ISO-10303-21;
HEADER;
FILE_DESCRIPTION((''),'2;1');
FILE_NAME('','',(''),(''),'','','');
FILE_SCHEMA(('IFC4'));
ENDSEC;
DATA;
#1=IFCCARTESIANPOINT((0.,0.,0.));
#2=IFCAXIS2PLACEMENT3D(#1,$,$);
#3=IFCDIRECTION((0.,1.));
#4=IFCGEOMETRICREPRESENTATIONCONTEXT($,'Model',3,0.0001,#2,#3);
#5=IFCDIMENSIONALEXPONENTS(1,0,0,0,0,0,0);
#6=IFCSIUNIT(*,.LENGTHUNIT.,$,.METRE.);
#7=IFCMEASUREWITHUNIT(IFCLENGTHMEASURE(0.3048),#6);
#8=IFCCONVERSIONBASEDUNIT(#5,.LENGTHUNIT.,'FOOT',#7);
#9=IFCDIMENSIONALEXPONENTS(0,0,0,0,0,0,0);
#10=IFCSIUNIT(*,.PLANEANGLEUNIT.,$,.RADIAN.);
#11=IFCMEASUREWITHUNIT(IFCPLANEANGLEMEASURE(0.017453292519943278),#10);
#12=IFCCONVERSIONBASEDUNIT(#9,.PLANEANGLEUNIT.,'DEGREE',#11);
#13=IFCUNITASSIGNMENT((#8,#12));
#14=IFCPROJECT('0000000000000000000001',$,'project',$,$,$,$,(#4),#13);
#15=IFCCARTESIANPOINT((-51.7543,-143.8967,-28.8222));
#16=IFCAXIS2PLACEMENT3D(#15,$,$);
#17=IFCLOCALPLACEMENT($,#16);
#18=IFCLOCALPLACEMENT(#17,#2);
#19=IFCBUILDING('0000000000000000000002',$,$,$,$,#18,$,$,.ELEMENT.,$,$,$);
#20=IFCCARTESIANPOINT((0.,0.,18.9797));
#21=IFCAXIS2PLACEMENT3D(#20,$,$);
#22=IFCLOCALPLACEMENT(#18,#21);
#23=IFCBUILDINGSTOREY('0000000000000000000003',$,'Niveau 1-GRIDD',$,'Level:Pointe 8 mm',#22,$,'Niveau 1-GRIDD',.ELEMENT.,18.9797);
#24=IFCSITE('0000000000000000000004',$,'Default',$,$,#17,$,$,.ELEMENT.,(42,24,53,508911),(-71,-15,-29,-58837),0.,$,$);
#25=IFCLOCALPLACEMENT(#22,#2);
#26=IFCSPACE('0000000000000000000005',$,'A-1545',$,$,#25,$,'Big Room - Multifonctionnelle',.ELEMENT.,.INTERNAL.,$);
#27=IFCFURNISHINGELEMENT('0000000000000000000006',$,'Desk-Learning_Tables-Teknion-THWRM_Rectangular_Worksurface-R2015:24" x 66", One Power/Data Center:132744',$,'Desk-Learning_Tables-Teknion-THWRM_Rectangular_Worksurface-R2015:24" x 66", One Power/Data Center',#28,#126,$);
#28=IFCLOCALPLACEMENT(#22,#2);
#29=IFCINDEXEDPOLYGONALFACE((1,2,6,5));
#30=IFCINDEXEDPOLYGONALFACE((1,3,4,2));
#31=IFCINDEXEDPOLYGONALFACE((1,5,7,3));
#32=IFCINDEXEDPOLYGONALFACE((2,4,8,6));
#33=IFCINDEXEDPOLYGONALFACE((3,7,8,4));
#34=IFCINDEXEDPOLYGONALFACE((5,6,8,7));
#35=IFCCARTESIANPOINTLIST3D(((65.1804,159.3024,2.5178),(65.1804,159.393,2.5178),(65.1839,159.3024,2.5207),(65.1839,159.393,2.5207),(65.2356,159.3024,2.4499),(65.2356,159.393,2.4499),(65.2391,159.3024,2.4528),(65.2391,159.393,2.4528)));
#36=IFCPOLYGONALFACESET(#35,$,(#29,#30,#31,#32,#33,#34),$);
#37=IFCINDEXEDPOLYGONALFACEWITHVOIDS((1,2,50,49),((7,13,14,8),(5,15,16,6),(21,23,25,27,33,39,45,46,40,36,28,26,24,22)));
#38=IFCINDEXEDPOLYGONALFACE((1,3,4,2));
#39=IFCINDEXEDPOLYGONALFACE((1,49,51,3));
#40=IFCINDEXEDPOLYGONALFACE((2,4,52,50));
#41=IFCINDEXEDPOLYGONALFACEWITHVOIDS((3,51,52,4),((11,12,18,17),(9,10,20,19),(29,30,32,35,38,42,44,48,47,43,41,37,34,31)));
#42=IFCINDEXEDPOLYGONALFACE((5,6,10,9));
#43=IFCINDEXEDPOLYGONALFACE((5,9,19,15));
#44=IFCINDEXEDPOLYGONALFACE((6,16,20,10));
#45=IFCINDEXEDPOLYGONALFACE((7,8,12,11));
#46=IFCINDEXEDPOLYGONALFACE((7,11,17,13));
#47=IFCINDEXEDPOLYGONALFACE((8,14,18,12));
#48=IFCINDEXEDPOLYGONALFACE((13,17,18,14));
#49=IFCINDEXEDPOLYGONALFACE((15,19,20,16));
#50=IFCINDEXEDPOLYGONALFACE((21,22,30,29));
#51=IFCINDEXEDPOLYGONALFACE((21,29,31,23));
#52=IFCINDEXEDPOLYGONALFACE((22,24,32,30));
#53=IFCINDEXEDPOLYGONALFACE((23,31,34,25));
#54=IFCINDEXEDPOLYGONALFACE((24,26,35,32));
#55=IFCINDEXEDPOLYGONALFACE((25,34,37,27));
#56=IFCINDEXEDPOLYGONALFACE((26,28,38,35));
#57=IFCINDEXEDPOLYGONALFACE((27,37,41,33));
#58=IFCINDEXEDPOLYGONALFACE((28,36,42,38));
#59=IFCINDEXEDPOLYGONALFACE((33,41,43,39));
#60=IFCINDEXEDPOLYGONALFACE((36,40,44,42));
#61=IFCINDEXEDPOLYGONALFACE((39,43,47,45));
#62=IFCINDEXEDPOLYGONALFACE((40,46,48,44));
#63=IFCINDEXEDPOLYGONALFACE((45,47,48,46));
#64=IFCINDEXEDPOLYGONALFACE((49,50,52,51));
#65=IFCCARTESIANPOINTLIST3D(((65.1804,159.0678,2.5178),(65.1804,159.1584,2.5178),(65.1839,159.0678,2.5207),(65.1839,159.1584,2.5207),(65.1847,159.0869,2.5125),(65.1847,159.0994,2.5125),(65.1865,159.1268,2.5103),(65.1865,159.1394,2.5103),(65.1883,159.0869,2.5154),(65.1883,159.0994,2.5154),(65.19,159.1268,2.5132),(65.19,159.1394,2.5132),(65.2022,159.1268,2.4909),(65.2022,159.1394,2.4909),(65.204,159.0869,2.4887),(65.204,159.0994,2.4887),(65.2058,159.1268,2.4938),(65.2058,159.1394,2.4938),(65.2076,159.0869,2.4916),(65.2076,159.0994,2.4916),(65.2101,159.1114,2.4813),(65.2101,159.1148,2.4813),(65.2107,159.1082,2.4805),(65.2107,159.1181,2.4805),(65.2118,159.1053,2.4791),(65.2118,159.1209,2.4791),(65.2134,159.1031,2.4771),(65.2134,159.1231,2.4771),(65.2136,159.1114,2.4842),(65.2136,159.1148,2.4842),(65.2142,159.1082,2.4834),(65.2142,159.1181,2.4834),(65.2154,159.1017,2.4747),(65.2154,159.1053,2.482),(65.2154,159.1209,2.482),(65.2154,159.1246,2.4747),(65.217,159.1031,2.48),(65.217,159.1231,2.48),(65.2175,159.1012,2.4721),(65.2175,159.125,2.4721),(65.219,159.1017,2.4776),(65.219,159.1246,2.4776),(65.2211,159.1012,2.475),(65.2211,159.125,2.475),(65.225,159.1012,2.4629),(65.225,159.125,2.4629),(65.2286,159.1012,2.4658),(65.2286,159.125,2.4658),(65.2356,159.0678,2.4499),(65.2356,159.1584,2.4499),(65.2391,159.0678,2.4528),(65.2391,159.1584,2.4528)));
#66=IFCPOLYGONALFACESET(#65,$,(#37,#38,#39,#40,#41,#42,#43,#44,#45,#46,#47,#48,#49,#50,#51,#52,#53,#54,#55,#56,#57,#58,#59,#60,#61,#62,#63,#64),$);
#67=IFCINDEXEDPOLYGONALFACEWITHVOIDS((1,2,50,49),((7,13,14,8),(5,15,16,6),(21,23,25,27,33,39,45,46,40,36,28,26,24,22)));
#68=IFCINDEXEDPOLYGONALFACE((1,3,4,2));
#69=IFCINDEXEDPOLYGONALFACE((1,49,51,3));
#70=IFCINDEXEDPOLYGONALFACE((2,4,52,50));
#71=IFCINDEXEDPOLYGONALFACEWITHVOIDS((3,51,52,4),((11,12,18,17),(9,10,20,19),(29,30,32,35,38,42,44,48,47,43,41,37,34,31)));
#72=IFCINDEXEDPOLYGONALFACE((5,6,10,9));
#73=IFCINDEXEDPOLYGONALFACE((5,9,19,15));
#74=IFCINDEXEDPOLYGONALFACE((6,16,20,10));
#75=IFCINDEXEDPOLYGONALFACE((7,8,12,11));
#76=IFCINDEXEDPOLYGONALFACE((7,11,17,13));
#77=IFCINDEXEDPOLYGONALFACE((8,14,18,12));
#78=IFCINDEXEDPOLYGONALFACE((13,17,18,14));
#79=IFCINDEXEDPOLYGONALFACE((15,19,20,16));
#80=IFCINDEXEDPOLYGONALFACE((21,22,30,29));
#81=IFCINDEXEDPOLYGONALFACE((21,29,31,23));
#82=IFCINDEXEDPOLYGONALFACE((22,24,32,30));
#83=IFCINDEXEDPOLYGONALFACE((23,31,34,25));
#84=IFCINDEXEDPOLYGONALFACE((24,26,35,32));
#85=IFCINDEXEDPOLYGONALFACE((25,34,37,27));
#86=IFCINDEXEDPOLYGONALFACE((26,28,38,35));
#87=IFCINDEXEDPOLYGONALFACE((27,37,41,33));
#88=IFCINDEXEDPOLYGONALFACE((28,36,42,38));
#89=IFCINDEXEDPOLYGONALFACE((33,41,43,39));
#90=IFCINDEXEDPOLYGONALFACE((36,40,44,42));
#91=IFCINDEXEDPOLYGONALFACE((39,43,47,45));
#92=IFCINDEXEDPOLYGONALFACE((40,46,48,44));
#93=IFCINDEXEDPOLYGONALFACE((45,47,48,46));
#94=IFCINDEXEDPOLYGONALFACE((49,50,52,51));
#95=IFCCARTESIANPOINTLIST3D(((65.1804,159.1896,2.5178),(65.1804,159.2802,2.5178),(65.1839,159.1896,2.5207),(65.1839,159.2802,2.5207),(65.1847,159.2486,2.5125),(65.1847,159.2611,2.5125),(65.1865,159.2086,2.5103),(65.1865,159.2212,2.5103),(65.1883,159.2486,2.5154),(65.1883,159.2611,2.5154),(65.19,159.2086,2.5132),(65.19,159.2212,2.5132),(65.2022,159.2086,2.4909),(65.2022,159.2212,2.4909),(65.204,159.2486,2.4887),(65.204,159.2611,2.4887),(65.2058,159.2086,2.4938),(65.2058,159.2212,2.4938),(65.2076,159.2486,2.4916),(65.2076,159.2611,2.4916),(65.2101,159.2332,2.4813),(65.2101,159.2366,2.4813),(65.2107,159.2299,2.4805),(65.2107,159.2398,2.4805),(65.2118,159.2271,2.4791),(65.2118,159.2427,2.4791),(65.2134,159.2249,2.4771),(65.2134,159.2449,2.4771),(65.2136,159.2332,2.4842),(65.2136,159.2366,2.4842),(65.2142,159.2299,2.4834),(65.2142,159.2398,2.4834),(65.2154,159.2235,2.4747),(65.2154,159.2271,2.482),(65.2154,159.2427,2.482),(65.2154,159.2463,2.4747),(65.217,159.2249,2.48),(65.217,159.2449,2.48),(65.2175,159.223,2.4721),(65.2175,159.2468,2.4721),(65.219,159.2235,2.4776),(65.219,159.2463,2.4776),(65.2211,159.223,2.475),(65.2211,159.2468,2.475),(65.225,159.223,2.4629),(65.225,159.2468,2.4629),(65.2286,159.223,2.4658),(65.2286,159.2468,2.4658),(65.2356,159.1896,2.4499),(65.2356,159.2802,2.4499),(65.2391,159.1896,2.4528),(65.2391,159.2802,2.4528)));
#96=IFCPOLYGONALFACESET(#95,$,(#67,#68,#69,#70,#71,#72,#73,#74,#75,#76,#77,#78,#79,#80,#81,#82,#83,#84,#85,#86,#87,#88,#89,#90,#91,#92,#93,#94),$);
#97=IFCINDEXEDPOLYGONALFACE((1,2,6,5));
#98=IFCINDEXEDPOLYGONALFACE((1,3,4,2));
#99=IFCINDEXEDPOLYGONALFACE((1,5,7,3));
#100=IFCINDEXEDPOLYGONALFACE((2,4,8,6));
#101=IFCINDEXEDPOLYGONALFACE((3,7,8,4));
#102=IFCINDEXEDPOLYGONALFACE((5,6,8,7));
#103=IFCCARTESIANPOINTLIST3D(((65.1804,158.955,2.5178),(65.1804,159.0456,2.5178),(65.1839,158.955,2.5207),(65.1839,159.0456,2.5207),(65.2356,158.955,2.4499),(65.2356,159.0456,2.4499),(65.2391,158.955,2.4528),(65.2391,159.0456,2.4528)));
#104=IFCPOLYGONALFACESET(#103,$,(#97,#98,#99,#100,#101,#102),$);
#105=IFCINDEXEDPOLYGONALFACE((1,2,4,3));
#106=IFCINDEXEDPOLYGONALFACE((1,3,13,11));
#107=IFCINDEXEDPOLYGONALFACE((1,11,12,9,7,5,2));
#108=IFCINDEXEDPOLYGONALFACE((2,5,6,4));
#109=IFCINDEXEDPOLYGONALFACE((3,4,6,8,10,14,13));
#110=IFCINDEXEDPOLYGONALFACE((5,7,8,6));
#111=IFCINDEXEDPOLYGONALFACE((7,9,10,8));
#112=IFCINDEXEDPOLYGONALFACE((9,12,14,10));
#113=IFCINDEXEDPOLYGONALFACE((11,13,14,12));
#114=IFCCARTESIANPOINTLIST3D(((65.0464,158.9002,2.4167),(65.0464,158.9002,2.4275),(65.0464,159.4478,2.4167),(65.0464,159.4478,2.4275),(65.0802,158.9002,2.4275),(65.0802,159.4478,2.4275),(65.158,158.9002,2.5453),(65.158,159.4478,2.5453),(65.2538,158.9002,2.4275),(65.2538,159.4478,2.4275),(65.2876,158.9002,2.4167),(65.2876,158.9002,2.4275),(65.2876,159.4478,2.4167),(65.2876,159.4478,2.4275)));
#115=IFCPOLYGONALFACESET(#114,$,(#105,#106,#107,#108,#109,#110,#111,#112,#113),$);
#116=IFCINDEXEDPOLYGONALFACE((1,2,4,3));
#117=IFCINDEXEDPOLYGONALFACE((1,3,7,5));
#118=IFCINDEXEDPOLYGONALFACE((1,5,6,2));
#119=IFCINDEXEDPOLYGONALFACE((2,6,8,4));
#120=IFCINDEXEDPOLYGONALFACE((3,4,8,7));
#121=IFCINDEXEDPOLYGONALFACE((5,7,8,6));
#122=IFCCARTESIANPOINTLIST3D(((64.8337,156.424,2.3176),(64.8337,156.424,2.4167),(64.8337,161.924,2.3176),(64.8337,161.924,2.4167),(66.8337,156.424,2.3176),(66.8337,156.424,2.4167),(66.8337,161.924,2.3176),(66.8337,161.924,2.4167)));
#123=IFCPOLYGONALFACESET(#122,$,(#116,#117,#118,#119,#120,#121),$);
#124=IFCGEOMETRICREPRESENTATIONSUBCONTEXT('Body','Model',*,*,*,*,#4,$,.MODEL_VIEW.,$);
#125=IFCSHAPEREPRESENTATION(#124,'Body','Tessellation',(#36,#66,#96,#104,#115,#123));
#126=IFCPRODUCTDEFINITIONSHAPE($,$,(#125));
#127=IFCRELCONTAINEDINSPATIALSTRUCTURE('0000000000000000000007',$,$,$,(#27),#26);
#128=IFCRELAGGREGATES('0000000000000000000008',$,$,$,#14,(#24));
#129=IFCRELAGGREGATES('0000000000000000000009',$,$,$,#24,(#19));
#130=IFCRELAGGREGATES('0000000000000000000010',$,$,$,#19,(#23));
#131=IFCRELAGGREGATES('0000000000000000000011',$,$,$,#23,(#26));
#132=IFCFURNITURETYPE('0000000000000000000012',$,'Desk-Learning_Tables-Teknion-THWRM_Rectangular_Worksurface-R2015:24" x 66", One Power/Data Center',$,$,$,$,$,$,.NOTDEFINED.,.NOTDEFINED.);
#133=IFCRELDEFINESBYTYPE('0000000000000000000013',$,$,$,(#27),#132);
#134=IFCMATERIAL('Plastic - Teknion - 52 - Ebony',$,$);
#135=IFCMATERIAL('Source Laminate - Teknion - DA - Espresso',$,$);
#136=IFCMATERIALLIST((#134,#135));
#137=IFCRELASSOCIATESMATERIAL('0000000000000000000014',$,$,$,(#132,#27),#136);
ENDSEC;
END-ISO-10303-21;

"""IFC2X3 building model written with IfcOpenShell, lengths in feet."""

from ifc_helpers import new_model, entity, si_unit, converted_unit, direction, frame, frame_2d, origin, place, context, subcontext, project, spatial, polyline, circle_curve, parameter, trimmed, segment, composite_curve, rectangle, outline, extrude, source, transform, mapped, material, material_list, type_object, type_shapes, element, save


model = new_model("IFC2X3")

# Units and contexts
model_context = context("Model", 3, precision=0.0001, world=origin(), true_north=direction((0.0, 1.0)))
body_context = subcontext(model_context, "Body", "Model", "MODEL_VIEW")
ifc_project = project(units=[converted_unit("LENGTHUNIT", "FOOT", entity("IfcLengthMeasure", 0.3048), si_unit("LENGTHUNIT", "METRE"), dimensions=[1, 0, 0, 0, 0, 0, 0]), converted_unit("PLANEANGLEUNIT", "DEGREE", entity("IfcPlaneAngleMeasure", 0.017453292519943278), si_unit("PLANEANGLEUNIT", "RADIAN"), dimensions=[0, 0, 0, 0, 0, 0, 0])], contexts=[model_context])

# Site, building, storey
site_placement = place(None, frame((-51.7543, -143.8967, -28.8222)))
site = spatial("IfcSite", under=ifc_project, at=site_placement, Name="Default", CompositionType="ELEMENT", RefLatitude=(42, 24, 53, 508911), RefLongitude=(-71, -15, -29, -58837), RefElevation=0.0)
building_placement = place(site_placement, origin())
building = spatial("IfcBuilding", under=site, at=building_placement, CompositionType="ELEMENT")
storey_placement = place(building_placement, frame((0.0, 0.0, 18.9797)))
storey = spatial("IfcBuildingStorey", under=building, at=storey_placement, Name="Niveau 1-GRIDD", ObjectType="Level:Pointe 8 mm", LongName="Niveau 1-GRIDD", CompositionType="ELEMENT", Elevation=18.9797)

# Shared definitions
space_placement = place(storey_placement, origin())
space = spatial("IfcSpace", under=storey, at=space_placement, Name="A-1545", LongName="Big Room - Multifonctionnelle", CompositionType="ELEMENT", InteriorOrExteriorSpace="INTERNAL")

# Furnishing element
ifc_material_1 = material(Name="Plastic - Teknion - 52 - Ebony")
ifc_material_2 = material(Name="Source Laminate - Teknion - DA - Espresso")
ifc_material_list_1 = material_list([ifc_material_1, ifc_material_2])
furniture_type_1 = type_object("IfcFurnitureType", Name="Desk-Learning_Tables-Teknion-THWRM_Rectangular_Worksurface-R2015:24\" x 66\", One Power/Data Center", AssemblyPlace="NOTDEFINED", material=ifc_material_list_1)
shared_shape_1 = source(origin(), body_context, "Body", "SweptSolid", [
    extrude(rectangle(XDim=0.0875, YDim=0.0046, at=frame_2d((0.0, 0.0), x_axis=(0.0, 1.0))), frame((0.1284, 0.6239, 2.4853), z_axis=(1.0, 0.0, 0.0), x_axis=(0.0, 0.776046, -0.630676)), (0.0, 0.0, 1.0), 0.0906),
    extrude(outline(polyline([(-0.0453, -0.0438), (0.0453, -0.0438), (0.0453, 0.0438), (-0.0453, 0.0438), (-0.0453, -0.0438)]), holes=[polyline([(-0.0262, -0.0063), (-0.0137, -0.0063), (-0.0137, -0.0369), (-0.0262, -0.0369), (-0.0262, -0.0063)]), polyline([(0.0137, -0.0341), (0.0137, -0.0091), (0.0262, -0.0091), (0.0262, -0.0341), (0.0137, -0.0341)]), composite_curve([segment(polyline([(-0.0119, 0.027), (0.0119, 0.027)]), True, "CONTINUOUS"), segment(polyline([(0.0119, 0.027), (0.0119, 0.0151)]), True, "CONTINUOUS"), segment(trimmed(circle_curve(frame_2d((0.0, 0.0151), x_axis=(0.0, -1.0)), 0.0119), [parameter(270.0)], [parameter(90.0)], True, "PARAMETER"), False, "CONTINUOUS"), segment(polyline([(-0.0119, 0.0151), (-0.0119, 0.027)]), True, "CONTINUOUS")], self_intersect=False)]), frame((-0.0609, 0.6221, 2.4867), z_axis=(0.0, 0.776046, -0.630676), x_axis=(1.0, 0.0, 0.0)), (0.0, 0.0, 1.0), 0.0046),
    extrude(outline(polyline([(-0.0438, -0.0453), (0.0438, -0.0453), (0.0438, 0.0453), (-0.0438, 0.0453), (-0.0438, -0.0453)]), holes=[polyline([(-0.0063, -0.0262), (-0.0369, -0.0262), (-0.0369, -0.0137), (-0.0063, -0.0137), (-0.0063, -0.0262)]), polyline([(-0.0341, 0.0137), (-0.0341, 0.0262), (-0.0091, 0.0262), (-0.0091, 0.0137), (-0.0341, 0.0137)]), composite_curve([segment(polyline([(0.027, -0.0119), (0.0151, -0.0119)]), True, "CONTINUOUS"), segment(trimmed(circle_curve(frame_2d((0.0151, 0.0), x_axis=(-1.0, 0.0)), 0.0119), [parameter(270.0)], [parameter(90.0)], True, "PARAMETER"), False, "CONTINUOUS"), segment(polyline([(0.0151, 0.0119), (0.027, 0.0119)]), True, "CONTINUOUS"), segment(polyline([(0.027, 0.0119), (0.027, -0.0119)]), True, "CONTINUOUS")], self_intersect=False)]), frame((0.0609, 0.6221, 2.4867), z_axis=(0.0, 0.776046, -0.630676), x_axis=(0.0, -0.630676, -0.776046)), (0.0, 0.0, 1.0), 0.0046),
    extrude(rectangle(XDim=0.0875, YDim=0.0046, at=frame_2d((0.0, 0.0), x_axis=(0.0, 1.0))), frame((-0.219, 0.6239, 2.4853), z_axis=(1.0, 0.0, 0.0), x_axis=(0.0, 0.776046, -0.630676)), (0.0, 0.0, 1.0), 0.0906),
    extrude(outline(polyline([(-0.0586, -0.0638), (0.0826, -0.0638), (0.0371, 0.0811), (0.0557, 0.1093), (0.0467, 0.1152), (-0.0862, -0.086), (-0.0772, -0.092), (-0.0586, -0.0638)])), frame((-0.2738, 0.6679, 2.4412), z_axis=(1.0, 0.0, 0.0), x_axis=(0.0, -0.551103, 0.834437)), (0.0, 0.0, 1.0), 0.5475),
    extrude(rectangle(XDim=5.5, YDim=2.0, at=frame_2d((0.0, 0.0), x_axis=(1.0, 0.0))), frame((0.0, 0.0, 2.3176), z_axis=(0.0, 0.0, 1.0), x_axis=(-1.0, 0.0, 0.0)), (0.0, 0.0, 1.0), 0.0991),
])
type_shapes(furniture_type_1, [shared_shape_1])
for number, where, z_axis, x_axis, name in (
    (1, (65.8337, 159.174, 0.0), (0.0, 0.0, 1.0), (0.0, 1.0, 0.0), "Desk-Learning_Tables-Teknion-THWRM_Rectangular_Worksurface-R2015:24\" x 66\", One Power/Data Center:132744"),
):
    element("IfcFurnishingElement", number, at=place(space_placement, frame(where, z_axis=z_axis, x_axis=x_axis)), inside=space, type_object=furniture_type_1, material=ifc_material_list_1, Name=name, ObjectType="Desk-Learning_Tables-Teknion-THWRM_Rectangular_Worksurface-R2015:24\" x 66\", One Power/Data Center", context=body_context, shape_type="MappedRepresentation", body=[
        mapped(shared_shape_1, transform((0.0, 0.0, 0.0), scale=1.0)),
    ])

save(model, "model.ifc")
